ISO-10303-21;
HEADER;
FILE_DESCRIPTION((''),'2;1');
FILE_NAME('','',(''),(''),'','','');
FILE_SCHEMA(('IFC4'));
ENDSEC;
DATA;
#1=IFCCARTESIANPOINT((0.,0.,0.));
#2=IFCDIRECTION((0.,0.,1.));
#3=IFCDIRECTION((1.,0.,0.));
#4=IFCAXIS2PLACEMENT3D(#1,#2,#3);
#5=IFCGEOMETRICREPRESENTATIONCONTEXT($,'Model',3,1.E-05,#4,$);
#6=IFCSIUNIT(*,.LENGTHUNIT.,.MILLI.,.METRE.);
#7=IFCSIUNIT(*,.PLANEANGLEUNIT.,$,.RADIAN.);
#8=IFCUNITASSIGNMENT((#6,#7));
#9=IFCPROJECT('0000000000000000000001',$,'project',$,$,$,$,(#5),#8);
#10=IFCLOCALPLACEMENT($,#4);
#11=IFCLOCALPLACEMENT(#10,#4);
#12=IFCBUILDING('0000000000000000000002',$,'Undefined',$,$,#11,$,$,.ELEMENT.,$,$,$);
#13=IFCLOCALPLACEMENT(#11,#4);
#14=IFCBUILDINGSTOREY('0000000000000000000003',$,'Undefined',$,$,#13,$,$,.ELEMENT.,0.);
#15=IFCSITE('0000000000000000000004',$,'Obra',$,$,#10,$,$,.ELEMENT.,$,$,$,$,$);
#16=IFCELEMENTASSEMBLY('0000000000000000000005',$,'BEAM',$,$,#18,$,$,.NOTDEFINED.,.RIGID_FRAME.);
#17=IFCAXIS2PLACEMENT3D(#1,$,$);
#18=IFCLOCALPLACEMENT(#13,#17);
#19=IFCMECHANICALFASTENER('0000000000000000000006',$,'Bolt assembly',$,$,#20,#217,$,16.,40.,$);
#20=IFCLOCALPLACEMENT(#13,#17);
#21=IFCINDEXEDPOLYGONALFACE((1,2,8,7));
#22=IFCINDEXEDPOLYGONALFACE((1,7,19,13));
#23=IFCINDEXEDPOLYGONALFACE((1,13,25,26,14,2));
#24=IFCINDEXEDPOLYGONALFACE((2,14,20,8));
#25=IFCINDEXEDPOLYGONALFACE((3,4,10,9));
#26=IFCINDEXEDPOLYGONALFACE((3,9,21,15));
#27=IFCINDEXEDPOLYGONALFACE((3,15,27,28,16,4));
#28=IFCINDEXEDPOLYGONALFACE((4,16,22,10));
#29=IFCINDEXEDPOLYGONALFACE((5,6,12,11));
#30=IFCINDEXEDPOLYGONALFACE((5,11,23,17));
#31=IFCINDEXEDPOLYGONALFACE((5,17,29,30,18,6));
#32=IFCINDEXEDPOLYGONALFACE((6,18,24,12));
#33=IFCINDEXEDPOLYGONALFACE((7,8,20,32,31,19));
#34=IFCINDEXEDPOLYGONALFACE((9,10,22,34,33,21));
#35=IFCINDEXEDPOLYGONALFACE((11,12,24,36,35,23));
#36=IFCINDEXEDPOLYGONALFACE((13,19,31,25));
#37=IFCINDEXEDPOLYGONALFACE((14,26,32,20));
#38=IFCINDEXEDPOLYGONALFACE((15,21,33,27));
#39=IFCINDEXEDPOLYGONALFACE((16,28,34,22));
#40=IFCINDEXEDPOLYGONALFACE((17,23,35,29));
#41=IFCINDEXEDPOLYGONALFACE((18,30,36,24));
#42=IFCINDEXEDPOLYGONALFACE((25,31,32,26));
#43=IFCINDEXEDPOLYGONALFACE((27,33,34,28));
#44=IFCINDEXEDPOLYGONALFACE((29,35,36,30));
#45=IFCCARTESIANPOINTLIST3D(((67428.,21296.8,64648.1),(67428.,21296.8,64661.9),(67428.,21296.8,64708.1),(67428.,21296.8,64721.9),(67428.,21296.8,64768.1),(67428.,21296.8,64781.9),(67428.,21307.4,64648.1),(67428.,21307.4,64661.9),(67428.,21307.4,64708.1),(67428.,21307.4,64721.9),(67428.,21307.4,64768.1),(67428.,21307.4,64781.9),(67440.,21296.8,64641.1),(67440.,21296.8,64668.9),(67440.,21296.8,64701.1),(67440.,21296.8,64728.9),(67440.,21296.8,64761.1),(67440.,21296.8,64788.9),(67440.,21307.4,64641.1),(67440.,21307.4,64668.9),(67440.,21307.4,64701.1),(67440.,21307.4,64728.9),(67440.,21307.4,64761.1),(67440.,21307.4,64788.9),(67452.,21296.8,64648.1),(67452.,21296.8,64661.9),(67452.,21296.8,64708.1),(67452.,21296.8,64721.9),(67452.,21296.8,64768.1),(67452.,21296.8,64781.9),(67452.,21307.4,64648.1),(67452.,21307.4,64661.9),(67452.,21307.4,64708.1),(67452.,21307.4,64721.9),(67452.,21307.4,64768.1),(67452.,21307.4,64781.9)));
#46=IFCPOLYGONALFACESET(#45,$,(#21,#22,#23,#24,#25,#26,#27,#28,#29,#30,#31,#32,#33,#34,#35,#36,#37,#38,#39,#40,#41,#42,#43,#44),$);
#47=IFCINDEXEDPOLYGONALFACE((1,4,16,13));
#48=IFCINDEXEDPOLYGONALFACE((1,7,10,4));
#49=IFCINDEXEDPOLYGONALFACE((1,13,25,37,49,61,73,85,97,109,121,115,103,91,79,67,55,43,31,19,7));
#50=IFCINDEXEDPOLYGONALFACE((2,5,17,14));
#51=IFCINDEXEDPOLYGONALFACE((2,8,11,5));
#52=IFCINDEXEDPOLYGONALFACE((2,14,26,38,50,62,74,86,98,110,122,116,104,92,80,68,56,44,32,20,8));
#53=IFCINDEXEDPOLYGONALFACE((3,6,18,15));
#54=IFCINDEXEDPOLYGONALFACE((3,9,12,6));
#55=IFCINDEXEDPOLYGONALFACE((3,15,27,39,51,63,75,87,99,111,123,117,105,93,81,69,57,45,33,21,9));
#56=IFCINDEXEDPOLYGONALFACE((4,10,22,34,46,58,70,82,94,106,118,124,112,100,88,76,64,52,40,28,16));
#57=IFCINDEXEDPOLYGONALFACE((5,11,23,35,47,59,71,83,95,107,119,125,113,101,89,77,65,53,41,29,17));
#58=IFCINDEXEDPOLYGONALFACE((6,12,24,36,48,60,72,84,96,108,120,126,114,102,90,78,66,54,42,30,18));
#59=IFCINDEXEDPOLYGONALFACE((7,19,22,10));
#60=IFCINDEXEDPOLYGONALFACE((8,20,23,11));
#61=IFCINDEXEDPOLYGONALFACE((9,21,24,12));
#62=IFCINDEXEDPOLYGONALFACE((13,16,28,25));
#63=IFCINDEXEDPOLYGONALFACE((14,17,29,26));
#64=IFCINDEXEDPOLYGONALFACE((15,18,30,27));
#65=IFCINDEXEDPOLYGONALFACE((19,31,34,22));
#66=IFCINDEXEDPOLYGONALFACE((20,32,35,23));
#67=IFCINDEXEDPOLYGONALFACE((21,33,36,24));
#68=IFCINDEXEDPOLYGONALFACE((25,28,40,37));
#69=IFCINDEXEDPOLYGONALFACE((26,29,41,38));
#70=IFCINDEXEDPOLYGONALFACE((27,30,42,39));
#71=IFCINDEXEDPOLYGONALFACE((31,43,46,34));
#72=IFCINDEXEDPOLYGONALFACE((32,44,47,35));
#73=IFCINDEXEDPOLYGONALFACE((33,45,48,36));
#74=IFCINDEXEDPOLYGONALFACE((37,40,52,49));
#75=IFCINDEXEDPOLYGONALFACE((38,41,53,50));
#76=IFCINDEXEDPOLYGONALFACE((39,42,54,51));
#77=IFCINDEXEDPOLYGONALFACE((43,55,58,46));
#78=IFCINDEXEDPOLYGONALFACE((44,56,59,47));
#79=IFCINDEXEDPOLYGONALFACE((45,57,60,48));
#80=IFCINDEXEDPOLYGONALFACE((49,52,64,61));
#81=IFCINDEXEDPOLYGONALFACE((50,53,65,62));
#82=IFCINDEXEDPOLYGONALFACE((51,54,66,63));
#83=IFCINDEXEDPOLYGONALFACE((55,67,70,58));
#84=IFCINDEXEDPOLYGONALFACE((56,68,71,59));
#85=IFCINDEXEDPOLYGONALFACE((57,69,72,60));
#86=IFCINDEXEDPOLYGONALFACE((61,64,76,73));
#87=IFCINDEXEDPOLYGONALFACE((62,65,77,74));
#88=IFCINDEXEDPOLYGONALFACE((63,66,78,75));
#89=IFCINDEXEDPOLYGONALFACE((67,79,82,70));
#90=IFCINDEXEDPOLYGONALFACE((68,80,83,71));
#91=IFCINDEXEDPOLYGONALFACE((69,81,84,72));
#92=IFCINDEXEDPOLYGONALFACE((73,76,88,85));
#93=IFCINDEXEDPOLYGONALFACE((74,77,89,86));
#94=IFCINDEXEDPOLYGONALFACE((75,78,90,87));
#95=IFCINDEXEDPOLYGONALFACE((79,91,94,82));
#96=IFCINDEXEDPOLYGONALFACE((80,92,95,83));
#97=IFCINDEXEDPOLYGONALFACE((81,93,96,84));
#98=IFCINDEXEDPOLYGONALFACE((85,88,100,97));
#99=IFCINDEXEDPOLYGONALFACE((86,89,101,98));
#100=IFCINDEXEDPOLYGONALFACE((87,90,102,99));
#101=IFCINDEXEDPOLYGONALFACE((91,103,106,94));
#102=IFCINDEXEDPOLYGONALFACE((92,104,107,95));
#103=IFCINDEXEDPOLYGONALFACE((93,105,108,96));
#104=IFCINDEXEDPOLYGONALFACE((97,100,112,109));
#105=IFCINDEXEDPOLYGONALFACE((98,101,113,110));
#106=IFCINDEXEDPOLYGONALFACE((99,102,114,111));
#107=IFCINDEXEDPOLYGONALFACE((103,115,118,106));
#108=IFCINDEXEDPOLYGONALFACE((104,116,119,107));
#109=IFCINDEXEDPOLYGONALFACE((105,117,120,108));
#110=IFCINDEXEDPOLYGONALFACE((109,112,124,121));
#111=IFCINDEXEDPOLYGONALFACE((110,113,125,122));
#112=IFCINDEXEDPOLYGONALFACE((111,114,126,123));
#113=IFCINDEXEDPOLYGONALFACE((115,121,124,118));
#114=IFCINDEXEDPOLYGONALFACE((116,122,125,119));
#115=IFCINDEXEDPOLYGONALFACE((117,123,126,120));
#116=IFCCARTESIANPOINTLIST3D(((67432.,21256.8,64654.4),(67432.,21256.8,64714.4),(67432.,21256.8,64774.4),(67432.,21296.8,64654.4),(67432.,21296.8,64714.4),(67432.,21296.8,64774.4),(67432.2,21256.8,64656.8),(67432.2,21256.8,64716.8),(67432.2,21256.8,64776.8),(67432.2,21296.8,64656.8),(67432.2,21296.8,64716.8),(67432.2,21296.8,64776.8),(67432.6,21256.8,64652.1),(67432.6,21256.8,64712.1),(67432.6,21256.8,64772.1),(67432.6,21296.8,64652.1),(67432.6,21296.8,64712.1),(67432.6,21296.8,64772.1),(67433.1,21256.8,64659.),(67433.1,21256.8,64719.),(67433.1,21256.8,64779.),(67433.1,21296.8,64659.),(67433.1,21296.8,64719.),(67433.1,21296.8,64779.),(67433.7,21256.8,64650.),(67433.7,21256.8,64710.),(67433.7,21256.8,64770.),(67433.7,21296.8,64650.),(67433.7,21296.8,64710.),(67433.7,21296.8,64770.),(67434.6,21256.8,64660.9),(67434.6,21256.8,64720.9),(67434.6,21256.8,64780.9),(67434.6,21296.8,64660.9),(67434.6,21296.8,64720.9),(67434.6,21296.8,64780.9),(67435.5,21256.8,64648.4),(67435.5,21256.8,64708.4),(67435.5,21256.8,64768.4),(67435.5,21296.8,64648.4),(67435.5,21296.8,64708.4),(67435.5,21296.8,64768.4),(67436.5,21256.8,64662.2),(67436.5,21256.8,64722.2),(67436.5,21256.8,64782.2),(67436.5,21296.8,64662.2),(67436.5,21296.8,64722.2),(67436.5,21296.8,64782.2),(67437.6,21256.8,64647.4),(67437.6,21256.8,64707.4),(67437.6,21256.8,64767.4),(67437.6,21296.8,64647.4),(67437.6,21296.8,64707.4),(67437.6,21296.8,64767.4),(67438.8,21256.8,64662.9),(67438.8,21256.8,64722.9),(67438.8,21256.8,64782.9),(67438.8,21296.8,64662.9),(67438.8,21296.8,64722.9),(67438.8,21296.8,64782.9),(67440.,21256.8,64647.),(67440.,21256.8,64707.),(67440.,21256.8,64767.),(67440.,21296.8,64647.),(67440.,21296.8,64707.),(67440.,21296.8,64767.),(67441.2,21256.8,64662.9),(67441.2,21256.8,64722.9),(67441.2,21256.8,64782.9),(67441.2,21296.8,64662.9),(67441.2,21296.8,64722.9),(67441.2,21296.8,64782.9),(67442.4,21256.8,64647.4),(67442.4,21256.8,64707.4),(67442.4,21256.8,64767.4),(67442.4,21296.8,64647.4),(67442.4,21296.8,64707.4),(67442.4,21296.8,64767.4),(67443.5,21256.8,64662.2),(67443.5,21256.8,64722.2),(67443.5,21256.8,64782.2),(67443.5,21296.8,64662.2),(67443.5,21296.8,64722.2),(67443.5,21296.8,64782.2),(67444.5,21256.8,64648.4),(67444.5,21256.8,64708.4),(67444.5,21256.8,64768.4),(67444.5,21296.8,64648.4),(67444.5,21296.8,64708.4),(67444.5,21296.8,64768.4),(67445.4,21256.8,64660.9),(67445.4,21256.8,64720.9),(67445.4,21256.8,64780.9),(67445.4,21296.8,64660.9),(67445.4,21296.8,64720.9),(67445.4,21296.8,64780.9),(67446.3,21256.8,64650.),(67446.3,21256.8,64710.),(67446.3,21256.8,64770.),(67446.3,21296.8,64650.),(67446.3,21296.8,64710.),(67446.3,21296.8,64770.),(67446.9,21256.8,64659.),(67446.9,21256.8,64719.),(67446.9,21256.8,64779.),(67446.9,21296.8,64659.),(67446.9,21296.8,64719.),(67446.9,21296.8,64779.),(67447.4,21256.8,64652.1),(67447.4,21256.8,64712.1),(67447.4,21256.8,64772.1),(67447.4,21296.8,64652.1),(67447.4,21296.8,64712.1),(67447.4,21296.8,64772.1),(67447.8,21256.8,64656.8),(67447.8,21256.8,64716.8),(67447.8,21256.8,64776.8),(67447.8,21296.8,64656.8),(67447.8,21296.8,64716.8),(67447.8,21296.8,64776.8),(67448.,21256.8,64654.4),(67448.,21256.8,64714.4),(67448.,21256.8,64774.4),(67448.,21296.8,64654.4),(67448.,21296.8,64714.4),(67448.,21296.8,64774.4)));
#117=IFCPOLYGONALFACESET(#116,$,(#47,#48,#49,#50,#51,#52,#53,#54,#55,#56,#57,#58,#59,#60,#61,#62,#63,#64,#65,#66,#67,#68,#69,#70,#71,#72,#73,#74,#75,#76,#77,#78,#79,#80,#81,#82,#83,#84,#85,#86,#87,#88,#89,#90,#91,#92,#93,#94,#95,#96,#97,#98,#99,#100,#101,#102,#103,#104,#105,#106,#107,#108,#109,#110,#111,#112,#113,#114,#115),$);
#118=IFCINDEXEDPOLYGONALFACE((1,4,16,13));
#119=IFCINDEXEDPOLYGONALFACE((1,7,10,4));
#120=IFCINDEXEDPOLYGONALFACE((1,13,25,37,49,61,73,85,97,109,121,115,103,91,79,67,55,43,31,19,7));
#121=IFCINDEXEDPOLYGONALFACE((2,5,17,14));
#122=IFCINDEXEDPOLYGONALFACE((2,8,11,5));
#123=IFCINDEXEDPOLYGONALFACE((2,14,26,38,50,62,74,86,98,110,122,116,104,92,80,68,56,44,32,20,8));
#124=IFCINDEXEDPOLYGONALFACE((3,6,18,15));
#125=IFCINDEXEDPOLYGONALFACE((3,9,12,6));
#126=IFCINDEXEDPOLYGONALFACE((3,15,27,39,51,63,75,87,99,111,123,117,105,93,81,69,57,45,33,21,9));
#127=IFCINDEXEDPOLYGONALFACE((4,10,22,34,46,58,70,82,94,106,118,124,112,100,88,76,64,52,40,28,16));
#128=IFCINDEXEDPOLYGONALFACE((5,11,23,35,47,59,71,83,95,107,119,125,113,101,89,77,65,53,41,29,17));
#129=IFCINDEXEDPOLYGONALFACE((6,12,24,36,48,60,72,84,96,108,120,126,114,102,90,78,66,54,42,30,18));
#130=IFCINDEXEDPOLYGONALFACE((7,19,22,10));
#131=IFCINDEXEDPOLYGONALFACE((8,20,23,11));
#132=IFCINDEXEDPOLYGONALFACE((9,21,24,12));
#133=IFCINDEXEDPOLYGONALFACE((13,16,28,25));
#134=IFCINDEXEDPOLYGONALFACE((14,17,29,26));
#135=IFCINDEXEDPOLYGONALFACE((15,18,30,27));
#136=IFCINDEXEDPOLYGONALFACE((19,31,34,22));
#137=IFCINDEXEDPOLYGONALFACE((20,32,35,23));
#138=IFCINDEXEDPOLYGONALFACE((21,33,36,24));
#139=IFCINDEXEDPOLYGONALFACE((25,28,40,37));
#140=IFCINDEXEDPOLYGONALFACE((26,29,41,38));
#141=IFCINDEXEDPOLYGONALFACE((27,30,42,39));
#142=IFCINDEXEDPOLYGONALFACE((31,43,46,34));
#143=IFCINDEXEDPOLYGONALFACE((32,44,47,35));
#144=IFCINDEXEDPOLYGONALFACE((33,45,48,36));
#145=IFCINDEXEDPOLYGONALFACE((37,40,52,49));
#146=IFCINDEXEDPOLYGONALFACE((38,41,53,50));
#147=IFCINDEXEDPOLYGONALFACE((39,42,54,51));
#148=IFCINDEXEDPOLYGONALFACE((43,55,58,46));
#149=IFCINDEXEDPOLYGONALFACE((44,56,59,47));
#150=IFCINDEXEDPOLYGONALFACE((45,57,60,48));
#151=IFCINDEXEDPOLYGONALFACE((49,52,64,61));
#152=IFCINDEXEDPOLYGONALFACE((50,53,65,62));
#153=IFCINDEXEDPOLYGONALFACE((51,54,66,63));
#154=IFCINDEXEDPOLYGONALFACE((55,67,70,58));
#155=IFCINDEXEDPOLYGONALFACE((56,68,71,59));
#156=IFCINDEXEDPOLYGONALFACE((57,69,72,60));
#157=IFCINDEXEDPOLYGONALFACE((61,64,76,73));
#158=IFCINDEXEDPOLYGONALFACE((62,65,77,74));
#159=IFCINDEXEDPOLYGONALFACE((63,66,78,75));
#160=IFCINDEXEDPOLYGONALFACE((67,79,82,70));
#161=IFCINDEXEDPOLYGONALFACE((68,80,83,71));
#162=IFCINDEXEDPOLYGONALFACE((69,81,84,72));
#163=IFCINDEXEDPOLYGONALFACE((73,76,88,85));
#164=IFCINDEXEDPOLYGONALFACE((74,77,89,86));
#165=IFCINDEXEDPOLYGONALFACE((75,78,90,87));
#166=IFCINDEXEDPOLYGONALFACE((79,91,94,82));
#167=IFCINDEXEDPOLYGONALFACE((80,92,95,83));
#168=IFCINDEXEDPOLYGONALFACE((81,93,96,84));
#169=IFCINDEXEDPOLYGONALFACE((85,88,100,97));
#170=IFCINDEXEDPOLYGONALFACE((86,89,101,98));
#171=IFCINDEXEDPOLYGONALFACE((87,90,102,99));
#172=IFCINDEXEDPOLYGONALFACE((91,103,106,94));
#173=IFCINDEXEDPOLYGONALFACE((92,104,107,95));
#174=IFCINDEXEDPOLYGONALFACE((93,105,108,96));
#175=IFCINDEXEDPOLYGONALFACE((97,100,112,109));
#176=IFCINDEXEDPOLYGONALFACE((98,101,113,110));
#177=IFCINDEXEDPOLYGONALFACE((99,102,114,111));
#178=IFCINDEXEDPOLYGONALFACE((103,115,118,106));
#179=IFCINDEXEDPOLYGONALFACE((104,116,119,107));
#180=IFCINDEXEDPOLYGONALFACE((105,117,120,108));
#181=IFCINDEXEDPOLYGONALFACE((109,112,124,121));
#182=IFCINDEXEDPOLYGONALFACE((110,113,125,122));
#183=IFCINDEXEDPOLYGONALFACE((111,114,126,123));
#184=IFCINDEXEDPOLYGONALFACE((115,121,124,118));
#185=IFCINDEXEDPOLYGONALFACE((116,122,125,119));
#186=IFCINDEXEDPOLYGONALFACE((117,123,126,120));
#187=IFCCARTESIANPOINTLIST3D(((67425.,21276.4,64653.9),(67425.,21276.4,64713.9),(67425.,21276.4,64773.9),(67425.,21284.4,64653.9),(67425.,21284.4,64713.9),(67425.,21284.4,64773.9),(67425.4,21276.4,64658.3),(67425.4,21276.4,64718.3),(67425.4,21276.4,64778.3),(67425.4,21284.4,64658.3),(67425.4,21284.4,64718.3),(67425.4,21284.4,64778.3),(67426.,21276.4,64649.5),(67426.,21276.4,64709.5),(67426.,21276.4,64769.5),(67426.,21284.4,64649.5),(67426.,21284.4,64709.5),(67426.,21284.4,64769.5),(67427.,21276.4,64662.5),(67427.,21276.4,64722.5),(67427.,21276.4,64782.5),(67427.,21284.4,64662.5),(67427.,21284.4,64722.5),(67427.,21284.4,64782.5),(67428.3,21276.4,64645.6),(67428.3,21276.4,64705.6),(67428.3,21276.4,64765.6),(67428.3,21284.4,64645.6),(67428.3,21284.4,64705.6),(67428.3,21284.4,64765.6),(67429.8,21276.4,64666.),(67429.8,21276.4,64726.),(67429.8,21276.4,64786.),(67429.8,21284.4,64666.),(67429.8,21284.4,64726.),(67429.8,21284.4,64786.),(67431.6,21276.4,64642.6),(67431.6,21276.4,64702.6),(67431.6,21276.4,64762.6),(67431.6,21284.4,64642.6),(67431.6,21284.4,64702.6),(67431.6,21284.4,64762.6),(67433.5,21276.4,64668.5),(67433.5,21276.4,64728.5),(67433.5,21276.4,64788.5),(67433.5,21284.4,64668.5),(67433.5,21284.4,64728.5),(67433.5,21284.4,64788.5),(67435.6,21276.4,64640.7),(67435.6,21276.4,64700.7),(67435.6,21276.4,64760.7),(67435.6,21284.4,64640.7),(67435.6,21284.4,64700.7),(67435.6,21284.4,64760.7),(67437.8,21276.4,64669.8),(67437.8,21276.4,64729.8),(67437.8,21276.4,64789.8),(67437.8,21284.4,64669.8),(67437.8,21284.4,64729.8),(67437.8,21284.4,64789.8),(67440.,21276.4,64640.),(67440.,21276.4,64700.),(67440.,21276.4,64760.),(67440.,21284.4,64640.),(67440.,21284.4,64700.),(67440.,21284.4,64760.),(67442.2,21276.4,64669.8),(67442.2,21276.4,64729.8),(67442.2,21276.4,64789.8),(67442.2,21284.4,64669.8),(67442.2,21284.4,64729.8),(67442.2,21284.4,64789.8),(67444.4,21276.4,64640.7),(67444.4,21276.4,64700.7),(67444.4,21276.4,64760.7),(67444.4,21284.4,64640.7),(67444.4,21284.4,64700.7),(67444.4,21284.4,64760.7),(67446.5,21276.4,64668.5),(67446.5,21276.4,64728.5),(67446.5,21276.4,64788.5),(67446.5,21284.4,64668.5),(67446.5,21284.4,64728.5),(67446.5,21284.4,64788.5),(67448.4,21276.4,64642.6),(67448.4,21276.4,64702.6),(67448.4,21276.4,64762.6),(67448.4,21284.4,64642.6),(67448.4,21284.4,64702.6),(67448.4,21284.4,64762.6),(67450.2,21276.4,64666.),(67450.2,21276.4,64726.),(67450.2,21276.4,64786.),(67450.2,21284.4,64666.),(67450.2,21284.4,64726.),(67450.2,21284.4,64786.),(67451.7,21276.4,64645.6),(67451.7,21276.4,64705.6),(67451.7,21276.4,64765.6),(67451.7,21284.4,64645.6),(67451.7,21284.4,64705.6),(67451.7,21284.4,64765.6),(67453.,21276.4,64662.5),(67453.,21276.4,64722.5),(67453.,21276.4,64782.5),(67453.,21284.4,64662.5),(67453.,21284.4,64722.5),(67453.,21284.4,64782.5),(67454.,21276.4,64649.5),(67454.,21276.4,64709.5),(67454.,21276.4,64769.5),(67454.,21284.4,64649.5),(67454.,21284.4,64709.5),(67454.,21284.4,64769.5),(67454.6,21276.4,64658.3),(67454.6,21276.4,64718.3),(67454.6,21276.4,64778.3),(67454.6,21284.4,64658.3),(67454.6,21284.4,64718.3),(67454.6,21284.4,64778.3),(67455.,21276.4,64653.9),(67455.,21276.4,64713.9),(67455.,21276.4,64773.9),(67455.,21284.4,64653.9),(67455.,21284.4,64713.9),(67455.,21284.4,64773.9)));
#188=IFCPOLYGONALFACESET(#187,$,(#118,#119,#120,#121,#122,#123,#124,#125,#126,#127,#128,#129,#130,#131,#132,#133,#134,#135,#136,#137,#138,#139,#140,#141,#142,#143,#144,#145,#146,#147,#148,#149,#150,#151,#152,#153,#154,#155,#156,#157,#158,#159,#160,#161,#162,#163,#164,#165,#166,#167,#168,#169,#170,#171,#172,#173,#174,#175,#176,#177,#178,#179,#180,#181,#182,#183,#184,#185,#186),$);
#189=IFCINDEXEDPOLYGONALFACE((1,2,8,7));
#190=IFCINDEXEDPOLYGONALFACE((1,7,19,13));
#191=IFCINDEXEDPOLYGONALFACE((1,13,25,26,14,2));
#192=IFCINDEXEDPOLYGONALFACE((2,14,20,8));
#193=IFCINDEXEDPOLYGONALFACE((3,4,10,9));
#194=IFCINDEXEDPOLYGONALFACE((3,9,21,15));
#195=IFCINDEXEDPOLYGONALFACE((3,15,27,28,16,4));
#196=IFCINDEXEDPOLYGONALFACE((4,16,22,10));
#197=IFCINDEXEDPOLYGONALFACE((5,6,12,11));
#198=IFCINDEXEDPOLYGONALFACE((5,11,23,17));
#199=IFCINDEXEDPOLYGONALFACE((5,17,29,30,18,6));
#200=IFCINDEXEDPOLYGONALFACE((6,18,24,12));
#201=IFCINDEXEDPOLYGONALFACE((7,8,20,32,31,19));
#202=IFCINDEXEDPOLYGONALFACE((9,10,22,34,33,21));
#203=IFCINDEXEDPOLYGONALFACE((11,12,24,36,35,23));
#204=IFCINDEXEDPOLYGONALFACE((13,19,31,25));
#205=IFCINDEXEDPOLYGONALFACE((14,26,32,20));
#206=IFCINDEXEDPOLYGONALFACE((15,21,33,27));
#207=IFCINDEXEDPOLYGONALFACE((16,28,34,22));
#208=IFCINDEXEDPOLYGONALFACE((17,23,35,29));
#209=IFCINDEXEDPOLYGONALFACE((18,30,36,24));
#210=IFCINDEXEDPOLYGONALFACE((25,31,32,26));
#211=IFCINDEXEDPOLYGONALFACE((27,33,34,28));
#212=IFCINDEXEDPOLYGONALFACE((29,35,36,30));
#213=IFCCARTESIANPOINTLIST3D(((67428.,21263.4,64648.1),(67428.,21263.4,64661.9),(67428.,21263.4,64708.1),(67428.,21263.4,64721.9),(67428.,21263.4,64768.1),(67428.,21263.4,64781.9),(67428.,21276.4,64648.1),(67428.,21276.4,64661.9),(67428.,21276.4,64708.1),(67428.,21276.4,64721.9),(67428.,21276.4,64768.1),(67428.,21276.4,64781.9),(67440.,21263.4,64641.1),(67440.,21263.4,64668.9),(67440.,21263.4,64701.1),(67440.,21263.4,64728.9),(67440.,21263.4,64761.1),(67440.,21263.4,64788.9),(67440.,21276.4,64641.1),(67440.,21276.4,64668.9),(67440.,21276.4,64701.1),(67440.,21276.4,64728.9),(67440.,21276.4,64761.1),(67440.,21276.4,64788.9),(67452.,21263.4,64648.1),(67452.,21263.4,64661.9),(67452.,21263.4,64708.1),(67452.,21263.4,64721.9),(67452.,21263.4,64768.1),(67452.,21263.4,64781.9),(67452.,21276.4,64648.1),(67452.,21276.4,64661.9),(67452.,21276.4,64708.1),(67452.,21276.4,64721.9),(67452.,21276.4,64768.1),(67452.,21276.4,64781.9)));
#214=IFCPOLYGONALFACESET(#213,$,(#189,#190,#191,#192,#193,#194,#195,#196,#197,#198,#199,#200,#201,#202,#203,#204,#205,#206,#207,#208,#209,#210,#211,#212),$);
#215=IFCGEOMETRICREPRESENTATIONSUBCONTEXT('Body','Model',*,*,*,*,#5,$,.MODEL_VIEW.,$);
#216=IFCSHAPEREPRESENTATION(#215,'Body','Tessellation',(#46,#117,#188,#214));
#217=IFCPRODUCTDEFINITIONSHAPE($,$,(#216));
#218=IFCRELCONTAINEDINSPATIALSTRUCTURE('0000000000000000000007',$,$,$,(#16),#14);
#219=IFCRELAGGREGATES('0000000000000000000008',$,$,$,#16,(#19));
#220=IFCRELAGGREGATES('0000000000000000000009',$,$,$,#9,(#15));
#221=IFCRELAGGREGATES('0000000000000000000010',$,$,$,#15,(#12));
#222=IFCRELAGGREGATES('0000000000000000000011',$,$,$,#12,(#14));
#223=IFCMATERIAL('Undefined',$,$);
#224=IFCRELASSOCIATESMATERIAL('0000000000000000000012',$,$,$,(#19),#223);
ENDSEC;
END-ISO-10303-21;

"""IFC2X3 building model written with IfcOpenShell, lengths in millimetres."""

from ifc_helpers import new_model, si_unit, frame, origin_with_axes, origin_2d_with_axis, place, context, subcontext, project, spatial, polyline, circle, outline, extrude, source, transform, mapped, material, element, aggregate, save


model = new_model("IFC2X3")

# Units and contexts
model_context = context("Model", 3, precision=1e-05, world=origin_with_axes())
body_context = subcontext(model_context, "Body", "Model", "MODEL_VIEW")
ifc_project = project(units=[si_unit("LENGTHUNIT", "METRE", prefix="MILLI"), si_unit("PLANEANGLEUNIT", "RADIAN")], contexts=[model_context])

# Site, building, storey
site_placement = place(None, origin_with_axes())
site = spatial("IfcSite", under=ifc_project, at=site_placement, Name="Obra", CompositionType="ELEMENT")
building_placement = place(site_placement, origin_with_axes())
building = spatial("IfcBuilding", under=site, at=building_placement, Name="Undefined", CompositionType="ELEMENT")
storey_placement = place(building_placement, origin_with_axes())
storey = spatial("IfcBuildingStorey", under=building, at=storey_placement, Name="Undefined", CompositionType="ELEMENT", Elevation=0.0)

# Shared definitions
ifc_material_1 = material(Name="Undefined")

# Element assembly, mechanical fastener
assembly_1_placement = place(storey_placement, origin_with_axes())
assembly_1 = element("IfcElementAssembly", 1, at=assembly_1_placement, inside=storey, Name="BEAM", AssemblyPlace="NOTDEFINED", PredefinedType="RIGID_FRAME")
shared_shape_1 = source(origin_with_axes(), body_context, "Body", "SweptSolid", [
    extrude(outline(polyline([(13.9, 0.0), (6.9, 12.0), (-6.9, 12.0), (-13.9, 0.0), (-6.9, -12.0), (6.9, -12.0), (13.9, 0.0)])), frame((0.0, -19.7, 0.0), z_axis=(0.0, 1.0, 0.0), x_axis=(1.0, 0.0, 0.0)), (0.0, 0.0, 1.0), 10.6),
    extrude(circle(Radius=8.0, at=origin_2d_with_axis()), frame((0.0, -9.1, 0.0), z_axis=(0.0, 1.0, 0.0), x_axis=(1.0, 0.0, 0.0)), (0.0, 0.0, 1.0), 40.0),
    extrude(circle(Radius=15.0, at=origin_2d_with_axis()), frame((0.0, 3.3, 0.0), z_axis=(0.0, 1.0, 0.0), x_axis=(1.0, 0.0, 0.0)), (0.0, 0.0, 1.0), 8.0),
    extrude(outline(polyline([(13.9, 0.0), (6.9, 12.0), (-6.9, 12.0), (-13.9, 0.0), (-6.9, -12.0), (6.9, -12.0), (13.9, 0.0)])), frame((0.0, 11.3, 0.0), z_axis=(0.0, 1.0, 0.0), x_axis=(1.0, 0.0, 0.0)), (0.0, 0.0, 1.0), 13.0),
])
mechanical_fastener_1_placement = place(assembly_1_placement, frame((67490.0, 21287.7, 64835.0), z_axis=(-1.0, 0.0, 0.0), x_axis=(0.0, 0.0, -1.0)))
mechanical_fastener_1 = element("IfcMechanicalFastener", 2, at=mechanical_fastener_1_placement, material=ifc_material_1, Name="Bolt assembly", NominalDiameter=16.0, NominalLength=40.0, context=body_context, shape_type="MappedRepresentation", body=[
    mapped(shared_shape_1, transform((60.0, 0.0, 50.0))),
    mapped(shared_shape_1, transform((120.0, 0.0, 50.0))),
    mapped(shared_shape_1, transform((180.0, 0.0, 50.0))),
])
aggregate(assembly_1, [mechanical_fastener_1])

save(model, "model.ifc")
